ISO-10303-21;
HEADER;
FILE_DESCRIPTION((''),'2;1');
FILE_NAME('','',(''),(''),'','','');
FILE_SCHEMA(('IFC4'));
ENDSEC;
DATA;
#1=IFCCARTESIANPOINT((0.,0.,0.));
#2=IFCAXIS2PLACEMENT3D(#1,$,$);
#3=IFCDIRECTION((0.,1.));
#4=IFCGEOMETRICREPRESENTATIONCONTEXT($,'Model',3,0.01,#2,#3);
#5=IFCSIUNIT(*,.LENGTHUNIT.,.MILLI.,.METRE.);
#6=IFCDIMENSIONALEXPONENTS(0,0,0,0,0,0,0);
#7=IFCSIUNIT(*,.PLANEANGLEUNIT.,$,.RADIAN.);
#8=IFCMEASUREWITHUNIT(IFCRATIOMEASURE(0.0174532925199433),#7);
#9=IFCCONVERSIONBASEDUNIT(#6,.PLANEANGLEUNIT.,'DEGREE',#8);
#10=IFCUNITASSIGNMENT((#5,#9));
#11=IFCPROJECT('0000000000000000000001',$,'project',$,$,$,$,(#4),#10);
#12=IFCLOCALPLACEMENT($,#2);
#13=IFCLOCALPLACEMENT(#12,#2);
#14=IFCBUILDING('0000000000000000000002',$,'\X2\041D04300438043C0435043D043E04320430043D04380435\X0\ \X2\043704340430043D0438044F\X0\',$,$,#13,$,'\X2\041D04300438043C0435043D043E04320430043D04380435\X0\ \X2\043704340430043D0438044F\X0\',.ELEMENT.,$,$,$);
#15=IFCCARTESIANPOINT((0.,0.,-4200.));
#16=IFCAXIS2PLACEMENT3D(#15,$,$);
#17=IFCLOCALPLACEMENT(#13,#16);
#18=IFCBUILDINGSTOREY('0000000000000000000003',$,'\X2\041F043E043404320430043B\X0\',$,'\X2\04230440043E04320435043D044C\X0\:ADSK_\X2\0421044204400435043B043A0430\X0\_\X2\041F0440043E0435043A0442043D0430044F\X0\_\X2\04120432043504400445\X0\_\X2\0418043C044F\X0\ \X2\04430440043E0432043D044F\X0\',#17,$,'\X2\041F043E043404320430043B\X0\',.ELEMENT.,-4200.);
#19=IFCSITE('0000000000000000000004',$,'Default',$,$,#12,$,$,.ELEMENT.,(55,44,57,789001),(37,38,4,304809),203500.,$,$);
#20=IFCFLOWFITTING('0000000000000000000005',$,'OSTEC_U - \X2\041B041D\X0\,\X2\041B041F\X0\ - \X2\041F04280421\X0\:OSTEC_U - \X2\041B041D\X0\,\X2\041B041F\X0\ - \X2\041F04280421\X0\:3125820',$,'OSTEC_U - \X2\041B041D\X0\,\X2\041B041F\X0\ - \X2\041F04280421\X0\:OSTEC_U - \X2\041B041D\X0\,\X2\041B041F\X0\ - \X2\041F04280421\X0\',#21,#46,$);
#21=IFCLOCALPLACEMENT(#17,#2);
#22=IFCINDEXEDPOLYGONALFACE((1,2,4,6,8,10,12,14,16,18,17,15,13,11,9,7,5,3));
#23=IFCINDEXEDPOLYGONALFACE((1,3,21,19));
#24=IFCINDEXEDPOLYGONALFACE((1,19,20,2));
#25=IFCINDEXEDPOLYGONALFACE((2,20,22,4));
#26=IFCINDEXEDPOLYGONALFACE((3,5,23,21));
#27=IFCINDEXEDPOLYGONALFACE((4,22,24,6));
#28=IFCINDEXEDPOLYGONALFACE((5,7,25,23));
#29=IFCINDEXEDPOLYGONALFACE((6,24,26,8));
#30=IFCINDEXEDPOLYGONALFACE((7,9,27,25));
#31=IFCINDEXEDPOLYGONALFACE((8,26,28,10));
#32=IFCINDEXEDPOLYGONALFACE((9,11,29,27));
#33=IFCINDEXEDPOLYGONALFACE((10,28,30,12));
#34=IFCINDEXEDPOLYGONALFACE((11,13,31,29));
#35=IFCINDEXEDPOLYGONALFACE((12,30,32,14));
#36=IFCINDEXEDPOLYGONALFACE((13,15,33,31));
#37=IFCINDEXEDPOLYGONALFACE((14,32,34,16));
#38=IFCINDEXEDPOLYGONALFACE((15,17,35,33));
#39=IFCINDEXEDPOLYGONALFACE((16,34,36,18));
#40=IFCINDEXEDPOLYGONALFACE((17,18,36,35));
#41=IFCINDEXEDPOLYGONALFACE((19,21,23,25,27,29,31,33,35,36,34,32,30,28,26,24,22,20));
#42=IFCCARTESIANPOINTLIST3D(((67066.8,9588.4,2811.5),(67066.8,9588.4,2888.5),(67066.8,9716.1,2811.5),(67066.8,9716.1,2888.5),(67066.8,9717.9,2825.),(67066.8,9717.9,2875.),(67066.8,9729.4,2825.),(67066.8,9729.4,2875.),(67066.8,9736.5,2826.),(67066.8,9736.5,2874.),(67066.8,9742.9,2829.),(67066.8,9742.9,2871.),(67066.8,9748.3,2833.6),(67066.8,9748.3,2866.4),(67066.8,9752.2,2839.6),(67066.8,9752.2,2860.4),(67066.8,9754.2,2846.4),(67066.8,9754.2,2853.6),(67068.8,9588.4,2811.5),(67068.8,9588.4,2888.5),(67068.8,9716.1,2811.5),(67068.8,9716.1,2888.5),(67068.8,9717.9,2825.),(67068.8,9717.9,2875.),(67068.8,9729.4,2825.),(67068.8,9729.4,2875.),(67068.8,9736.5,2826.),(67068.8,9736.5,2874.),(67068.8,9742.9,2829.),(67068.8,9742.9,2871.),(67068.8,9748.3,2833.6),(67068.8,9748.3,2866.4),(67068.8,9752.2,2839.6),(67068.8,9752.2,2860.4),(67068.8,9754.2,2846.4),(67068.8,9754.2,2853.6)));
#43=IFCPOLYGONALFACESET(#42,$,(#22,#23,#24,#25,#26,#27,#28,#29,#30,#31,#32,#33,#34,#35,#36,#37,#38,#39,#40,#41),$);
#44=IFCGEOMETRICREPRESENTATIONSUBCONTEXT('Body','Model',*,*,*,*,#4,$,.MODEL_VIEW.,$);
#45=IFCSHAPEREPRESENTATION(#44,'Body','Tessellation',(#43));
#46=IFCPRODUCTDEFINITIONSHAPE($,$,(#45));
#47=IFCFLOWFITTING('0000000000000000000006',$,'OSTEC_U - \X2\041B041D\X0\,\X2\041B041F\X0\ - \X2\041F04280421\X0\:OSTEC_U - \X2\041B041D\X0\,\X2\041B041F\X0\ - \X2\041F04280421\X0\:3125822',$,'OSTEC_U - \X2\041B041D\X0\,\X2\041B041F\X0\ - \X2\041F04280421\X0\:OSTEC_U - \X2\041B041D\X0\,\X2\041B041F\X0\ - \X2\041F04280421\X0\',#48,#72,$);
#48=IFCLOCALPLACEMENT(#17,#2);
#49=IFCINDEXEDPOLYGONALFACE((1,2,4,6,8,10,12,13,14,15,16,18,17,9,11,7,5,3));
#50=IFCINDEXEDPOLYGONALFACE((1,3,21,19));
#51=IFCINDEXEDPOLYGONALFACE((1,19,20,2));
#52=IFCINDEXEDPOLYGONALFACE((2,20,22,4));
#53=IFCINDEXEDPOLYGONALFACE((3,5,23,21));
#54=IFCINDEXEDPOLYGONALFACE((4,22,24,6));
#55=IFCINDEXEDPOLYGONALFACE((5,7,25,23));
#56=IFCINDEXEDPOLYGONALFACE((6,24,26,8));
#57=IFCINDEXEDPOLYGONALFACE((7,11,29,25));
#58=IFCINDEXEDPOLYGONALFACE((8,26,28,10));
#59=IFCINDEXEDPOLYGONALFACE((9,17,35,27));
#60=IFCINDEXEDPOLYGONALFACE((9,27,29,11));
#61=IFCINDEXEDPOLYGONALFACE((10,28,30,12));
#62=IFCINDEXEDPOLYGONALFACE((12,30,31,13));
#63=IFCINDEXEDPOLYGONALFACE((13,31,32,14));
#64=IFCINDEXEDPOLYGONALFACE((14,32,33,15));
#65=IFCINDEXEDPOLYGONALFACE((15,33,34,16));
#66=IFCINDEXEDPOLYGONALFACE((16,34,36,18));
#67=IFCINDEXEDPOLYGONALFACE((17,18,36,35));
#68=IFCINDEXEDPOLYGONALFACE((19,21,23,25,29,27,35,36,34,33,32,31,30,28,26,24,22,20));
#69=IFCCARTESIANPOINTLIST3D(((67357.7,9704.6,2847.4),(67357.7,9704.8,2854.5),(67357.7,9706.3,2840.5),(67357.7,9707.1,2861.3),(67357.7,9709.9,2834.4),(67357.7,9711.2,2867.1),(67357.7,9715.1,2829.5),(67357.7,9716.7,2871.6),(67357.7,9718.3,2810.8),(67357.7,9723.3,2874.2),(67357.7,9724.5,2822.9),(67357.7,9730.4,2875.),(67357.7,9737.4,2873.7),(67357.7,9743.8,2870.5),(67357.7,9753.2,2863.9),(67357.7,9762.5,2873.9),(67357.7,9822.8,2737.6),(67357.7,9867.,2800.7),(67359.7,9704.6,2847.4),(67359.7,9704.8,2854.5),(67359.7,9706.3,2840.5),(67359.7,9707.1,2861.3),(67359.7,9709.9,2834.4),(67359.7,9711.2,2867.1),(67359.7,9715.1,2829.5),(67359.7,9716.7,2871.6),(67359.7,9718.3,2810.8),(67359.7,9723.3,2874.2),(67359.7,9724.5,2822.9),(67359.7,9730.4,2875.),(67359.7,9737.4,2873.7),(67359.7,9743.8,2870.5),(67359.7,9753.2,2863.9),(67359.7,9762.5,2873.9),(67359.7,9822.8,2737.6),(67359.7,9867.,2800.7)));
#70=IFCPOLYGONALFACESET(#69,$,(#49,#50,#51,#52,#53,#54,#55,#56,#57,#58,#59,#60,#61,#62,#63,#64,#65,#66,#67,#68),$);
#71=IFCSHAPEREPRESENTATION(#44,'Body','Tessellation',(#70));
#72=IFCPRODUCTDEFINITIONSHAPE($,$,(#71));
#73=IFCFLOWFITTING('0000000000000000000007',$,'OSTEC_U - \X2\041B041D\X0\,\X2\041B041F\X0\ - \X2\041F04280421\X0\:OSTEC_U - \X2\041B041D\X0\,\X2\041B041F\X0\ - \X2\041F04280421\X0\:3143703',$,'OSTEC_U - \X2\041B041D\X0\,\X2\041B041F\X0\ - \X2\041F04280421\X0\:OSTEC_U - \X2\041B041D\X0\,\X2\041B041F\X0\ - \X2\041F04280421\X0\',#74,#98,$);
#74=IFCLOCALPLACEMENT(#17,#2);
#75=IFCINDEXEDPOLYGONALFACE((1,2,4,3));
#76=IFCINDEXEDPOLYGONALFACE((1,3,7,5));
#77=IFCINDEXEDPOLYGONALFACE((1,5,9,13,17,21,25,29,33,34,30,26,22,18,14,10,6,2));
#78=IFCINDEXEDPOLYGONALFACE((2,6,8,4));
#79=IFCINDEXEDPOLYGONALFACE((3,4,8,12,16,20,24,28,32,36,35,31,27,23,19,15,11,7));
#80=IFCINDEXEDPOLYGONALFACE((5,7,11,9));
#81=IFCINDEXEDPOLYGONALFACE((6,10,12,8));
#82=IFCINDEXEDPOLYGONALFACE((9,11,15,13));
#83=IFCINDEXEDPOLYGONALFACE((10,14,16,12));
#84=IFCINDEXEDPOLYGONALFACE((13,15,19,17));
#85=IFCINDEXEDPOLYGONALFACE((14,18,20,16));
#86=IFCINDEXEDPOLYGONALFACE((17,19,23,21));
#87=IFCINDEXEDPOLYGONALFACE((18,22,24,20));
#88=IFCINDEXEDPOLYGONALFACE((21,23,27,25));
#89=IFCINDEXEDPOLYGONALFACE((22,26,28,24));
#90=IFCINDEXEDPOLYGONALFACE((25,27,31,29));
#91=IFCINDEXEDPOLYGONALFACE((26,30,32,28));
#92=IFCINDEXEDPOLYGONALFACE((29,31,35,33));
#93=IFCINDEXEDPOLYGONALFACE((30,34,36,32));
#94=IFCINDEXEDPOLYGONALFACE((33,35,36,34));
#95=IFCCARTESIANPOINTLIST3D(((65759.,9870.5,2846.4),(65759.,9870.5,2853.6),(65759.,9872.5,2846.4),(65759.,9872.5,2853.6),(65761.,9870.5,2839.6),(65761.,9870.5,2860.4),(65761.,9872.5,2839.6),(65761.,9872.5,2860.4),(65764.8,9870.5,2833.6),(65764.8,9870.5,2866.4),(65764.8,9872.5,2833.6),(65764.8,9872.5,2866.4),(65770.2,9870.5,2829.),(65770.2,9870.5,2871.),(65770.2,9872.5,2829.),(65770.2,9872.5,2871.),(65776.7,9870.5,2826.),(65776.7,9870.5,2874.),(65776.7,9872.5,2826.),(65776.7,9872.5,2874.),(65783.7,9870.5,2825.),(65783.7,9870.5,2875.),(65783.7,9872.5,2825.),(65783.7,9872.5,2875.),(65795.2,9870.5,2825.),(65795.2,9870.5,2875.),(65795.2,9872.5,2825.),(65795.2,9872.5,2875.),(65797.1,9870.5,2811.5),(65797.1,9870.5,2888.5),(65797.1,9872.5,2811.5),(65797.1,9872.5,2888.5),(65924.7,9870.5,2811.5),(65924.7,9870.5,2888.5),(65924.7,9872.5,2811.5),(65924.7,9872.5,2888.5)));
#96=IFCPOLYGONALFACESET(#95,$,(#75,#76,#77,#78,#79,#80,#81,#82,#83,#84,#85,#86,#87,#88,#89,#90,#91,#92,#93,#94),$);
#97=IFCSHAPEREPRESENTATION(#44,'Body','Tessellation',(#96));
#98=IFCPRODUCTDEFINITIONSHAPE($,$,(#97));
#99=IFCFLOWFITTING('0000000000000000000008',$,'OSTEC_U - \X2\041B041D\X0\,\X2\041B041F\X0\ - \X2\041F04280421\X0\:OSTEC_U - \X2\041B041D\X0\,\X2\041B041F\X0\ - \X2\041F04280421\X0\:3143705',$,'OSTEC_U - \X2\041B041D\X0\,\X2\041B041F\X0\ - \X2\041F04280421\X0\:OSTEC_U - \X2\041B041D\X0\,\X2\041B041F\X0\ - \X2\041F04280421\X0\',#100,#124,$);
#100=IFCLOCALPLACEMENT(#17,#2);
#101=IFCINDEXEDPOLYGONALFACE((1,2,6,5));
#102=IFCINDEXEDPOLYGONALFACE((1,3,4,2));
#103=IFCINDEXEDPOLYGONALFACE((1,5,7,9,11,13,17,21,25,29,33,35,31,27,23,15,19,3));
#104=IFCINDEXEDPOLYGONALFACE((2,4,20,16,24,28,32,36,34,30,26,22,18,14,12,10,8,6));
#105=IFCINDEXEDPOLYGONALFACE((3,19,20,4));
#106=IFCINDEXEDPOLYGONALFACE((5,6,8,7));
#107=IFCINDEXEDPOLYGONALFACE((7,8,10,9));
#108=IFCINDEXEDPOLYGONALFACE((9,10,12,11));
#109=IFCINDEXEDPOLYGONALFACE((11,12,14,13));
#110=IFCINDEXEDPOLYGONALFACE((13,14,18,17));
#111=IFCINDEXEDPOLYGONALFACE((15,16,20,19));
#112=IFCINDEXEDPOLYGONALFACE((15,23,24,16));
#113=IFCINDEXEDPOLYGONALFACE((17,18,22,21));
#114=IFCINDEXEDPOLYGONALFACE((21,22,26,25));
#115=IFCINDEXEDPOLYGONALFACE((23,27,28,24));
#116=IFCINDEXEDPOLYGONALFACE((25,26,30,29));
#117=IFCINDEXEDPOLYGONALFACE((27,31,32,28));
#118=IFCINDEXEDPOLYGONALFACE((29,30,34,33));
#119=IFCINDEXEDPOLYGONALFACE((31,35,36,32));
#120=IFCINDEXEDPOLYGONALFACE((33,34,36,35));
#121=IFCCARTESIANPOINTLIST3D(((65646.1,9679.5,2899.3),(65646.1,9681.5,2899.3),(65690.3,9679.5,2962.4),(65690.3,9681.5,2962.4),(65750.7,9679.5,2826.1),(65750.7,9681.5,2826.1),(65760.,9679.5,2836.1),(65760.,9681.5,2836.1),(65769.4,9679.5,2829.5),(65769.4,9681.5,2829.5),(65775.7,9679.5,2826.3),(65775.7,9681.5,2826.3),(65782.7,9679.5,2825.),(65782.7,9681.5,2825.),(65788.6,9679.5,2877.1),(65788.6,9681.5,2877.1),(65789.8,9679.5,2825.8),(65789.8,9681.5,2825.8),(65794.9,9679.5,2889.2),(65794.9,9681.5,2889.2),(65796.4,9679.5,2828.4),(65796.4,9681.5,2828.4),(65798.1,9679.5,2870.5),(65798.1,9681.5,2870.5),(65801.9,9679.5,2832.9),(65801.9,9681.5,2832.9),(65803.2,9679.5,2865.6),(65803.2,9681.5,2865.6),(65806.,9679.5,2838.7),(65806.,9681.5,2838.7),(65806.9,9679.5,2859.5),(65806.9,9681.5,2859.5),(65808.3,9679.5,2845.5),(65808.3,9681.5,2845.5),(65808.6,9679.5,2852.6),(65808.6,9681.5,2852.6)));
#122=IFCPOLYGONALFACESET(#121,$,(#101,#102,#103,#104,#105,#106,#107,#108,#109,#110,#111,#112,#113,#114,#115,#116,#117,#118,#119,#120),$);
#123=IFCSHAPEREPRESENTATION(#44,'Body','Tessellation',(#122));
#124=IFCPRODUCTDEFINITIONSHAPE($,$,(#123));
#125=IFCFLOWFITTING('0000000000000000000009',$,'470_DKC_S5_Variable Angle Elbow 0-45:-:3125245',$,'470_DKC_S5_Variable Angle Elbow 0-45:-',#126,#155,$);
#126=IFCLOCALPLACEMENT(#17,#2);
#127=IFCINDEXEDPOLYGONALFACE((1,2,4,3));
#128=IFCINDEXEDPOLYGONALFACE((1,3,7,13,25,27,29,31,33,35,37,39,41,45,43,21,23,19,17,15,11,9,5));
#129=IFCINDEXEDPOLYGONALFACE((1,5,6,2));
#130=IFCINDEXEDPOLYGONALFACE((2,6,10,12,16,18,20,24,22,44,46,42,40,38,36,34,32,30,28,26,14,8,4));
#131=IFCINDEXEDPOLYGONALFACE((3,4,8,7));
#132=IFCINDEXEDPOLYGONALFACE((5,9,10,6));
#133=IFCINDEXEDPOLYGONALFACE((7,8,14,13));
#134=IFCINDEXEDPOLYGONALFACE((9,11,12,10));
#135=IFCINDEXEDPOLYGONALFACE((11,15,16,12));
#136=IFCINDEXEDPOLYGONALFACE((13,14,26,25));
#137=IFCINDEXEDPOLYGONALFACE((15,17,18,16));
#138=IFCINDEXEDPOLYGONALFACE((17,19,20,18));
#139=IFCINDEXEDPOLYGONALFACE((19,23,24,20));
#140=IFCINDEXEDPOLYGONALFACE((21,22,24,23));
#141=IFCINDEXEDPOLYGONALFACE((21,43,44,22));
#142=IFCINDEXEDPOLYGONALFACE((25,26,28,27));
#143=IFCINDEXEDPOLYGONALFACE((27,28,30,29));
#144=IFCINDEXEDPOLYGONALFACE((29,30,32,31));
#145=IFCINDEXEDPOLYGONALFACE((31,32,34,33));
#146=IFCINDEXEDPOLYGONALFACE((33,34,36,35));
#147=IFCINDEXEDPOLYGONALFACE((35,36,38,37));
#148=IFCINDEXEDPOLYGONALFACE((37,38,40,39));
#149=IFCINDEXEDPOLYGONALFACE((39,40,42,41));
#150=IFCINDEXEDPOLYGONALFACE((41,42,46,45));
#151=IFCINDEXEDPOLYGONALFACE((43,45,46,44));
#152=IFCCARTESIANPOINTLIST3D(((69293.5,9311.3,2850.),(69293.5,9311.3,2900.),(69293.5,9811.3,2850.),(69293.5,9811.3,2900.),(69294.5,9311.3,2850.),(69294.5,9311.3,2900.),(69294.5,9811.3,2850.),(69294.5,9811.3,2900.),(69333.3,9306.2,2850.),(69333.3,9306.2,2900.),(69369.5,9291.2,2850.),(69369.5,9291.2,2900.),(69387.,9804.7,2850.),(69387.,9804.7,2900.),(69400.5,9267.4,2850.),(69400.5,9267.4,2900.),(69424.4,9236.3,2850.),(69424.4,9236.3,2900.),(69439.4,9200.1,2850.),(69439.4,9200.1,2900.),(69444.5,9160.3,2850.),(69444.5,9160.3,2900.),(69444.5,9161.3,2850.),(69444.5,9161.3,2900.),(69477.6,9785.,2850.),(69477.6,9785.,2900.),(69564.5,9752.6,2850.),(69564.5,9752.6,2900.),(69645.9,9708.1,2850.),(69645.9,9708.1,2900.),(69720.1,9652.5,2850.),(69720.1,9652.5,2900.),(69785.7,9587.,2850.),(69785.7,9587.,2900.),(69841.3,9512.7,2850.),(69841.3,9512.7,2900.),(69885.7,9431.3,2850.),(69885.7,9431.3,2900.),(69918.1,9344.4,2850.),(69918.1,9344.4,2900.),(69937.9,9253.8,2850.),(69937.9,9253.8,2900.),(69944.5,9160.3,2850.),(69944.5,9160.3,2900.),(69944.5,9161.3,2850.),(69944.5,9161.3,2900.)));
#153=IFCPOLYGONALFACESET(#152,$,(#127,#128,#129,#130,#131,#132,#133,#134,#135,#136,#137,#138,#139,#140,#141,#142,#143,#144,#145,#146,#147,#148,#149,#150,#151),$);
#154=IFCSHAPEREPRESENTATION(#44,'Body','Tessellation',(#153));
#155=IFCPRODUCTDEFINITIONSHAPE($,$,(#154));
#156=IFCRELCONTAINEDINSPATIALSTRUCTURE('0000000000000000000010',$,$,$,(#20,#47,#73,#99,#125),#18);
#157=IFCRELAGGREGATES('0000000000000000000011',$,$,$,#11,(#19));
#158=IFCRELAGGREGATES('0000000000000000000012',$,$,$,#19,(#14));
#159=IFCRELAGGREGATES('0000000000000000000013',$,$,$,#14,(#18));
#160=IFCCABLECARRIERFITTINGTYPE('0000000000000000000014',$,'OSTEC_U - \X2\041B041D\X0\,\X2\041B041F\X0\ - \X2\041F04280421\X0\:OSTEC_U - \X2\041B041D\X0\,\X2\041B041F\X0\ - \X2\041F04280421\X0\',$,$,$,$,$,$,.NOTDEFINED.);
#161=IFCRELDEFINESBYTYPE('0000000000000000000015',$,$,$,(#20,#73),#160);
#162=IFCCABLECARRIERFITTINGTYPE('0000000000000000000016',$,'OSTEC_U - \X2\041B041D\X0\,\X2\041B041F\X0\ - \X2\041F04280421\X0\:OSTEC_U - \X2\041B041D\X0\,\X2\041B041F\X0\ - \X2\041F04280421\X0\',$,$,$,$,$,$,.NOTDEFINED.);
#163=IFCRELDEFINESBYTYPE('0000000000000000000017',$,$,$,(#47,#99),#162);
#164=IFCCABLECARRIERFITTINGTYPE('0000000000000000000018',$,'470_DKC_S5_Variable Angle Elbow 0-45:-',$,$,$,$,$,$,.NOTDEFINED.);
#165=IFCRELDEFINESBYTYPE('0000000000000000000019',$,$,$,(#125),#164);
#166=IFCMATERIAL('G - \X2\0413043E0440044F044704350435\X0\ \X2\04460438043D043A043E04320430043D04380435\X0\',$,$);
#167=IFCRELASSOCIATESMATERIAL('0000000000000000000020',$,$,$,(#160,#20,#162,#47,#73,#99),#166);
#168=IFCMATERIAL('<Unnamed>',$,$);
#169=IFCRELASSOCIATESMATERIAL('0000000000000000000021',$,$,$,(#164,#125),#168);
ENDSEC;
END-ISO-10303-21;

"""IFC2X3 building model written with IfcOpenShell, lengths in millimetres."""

from ifc_helpers import new_model, entity, si_unit, converted_unit, direction, frame, frame_2d, origin, place, context, subcontext, project, spatial, polyline, circle_curve, parameter, trimmed, segment, composite_curve, outline, extrude, source, transform, mapped, material, type_object, type_shapes, element, save


model = new_model("IFC2X3")

# Units and contexts
model_context = context("Model", 3, precision=0.01, world=origin(), true_north=direction((0.0, 1.0)))
body_context = subcontext(model_context, "Body", "Model", "MODEL_VIEW")
ifc_project = project(units=[si_unit("LENGTHUNIT", "METRE", prefix="MILLI"), converted_unit("PLANEANGLEUNIT", "DEGREE", entity("IfcRatioMeasure", 0.0174532925199433), si_unit("PLANEANGLEUNIT", "RADIAN"), dimensions=[0, 0, 0, 0, 0, 0, 0])], contexts=[model_context])

# Site, building, storey
site_placement = place(None, origin())
site = spatial("IfcSite", under=ifc_project, at=site_placement, Name="Default", CompositionType="ELEMENT", RefLatitude=(55, 44, 57, 789001), RefLongitude=(37, 38, 4, 304809), RefElevation=203500.0)
building_placement = place(site_placement, origin())
building = spatial("IfcBuilding", under=site, at=building_placement, Name="Наименование здания", LongName="Наименование здания", CompositionType="ELEMENT")
storey_placement = place(building_placement, frame((0.0, 0.0, -4200.0)))
storey = spatial("IfcBuildingStorey", under=building, at=storey_placement, Name="Подвал", ObjectType="Уровень:ADSK_Стрелка_Проектная_Вверх_Имя уровня", LongName="Подвал", CompositionType="ELEMENT", Elevation=-4200.0)

# Flow fittings
ifc_material_1 = material(Name="G - Горячее цинкование")
cable_carrier_fitting_type_1 = type_object("IfcCableCarrierFittingType", Name="OSTEC_U - ЛН,ЛП - ПШС:OSTEC_U - ЛН,ЛП - ПШС", PredefinedType="NOTDEFINED", material=ifc_material_1)
shared_shape_1 = source(origin(), body_context, "Body", "SweptSolid", [
    extrude(outline(composite_curve([segment(trimmed(circle_curve(frame_2d((-41.5, 0.0), x_axis=(1.0, 0.0)), 25.0), [parameter(90.0)], [parameter(270.0)], True, "PARAMETER"), True, "CONTINUOUS"), segment(polyline([(-41.5, -25.0), (-30.0, -25.0)]), True, "CONTINUOUS"), segment(polyline([(-30.0, -25.0), (-28.1, -38.5)]), True, "CONTINUOUS"), segment(polyline([(-28.1, -38.5), (99.5, -38.5)]), True, "CONTINUOUS"), segment(polyline([(99.5, -38.5), (99.5, 38.5)]), True, "CONTINUOUS"), segment(polyline([(99.5, 38.5), (-28.1, 38.5)]), True, "CONTINUOUS"), segment(polyline([(-28.1, 38.5), (-30.0, 25.0)]), True, "CONTINUOUS"), segment(polyline([(-30.0, 25.0), (-41.5, 25.0)]), True, "CONTINUOUS")], self_intersect=False)), frame((41.5, 0.0, 0.0)), (0.0, 0.0, 1.0), 2.0),
])
type_shapes(cable_carrier_fitting_type_1, [shared_shape_1])
flow_fitting_1_placement = place(storey_placement, frame((67068.8, 9729.4, 2850.0), z_axis=(-1.0, 0.0, 0.0), x_axis=(0.0, -1.0, 0.0)))
element("IfcFlowFitting", 1, at=flow_fitting_1_placement, inside=storey, type_object=cable_carrier_fitting_type_1, material=ifc_material_1, Name="OSTEC_U - ЛН,ЛП - ПШС:OSTEC_U - ЛН,ЛП - ПШС:3125820", ObjectType="OSTEC_U - ЛН,ЛП - ПШС:OSTEC_U - ЛН,ЛП - ПШС", context=body_context, shape_type="MappedRepresentation", body=[
    mapped(shared_shape_1, transform((0.0, 0.0, 0.0), scale=1.0)),
])
cable_carrier_fitting_type_2 = type_object("IfcCableCarrierFittingType", Name="OSTEC_U - ЛН,ЛП - ПШС:OSTEC_U - ЛН,ЛП - ПШС", PredefinedType="NOTDEFINED", material=ifc_material_1)
type_shapes(cable_carrier_fitting_type_2, [shared_shape_1])
flow_fitting_2_placement = place(storey_placement, frame((67357.7, 9729.4, 2850.0), z_axis=(1.0, 0.0, 0.0), x_axis=(0.0, 0.819152, -0.573576)))
element("IfcFlowFitting", 2, at=flow_fitting_2_placement, inside=storey, type_object=cable_carrier_fitting_type_2, material=ifc_material_1, Name="OSTEC_U - ЛН,ЛП - ПШС:OSTEC_U - ЛН,ЛП - ПШС:3125822", ObjectType="OSTEC_U - ЛН,ЛП - ПШС:OSTEC_U - ЛН,ЛП - ПШС", context=body_context, shape_type="MappedRepresentation", body=[
    mapped(shared_shape_1, transform((0.0, 0.0, 0.0), scale=1.0)),
])
flow_fitting_3_placement = place(storey_placement, frame((65783.7, 9870.5, 2850.0), z_axis=(0.0, 1.0, 0.0), x_axis=(1.0, 0.0, 0.0)))
element("IfcFlowFitting", 3, at=flow_fitting_3_placement, inside=storey, type_object=cable_carrier_fitting_type_1, material=ifc_material_1, Name="OSTEC_U - ЛН,ЛП - ПШС:OSTEC_U - ЛН,ЛП - ПШС:3143703", ObjectType="OSTEC_U - ЛН,ЛП - ПШС:OSTEC_U - ЛН,ЛП - ПШС", context=body_context, shape_type="MappedRepresentation", body=[
    mapped(shared_shape_1, transform((0.0, 0.0, 0.0), scale=1.0)),
])
flow_fitting_4_placement = place(storey_placement, frame((65783.7, 9681.5, 2850.0), z_axis=(0.0, -1.0, 0.0), x_axis=(-0.819152, 0.0, 0.573576)))
element("IfcFlowFitting", 4, at=flow_fitting_4_placement, inside=storey, type_object=cable_carrier_fitting_type_2, material=ifc_material_1, Name="OSTEC_U - ЛН,ЛП - ПШС:OSTEC_U - ЛН,ЛП - ПШС:3143705", ObjectType="OSTEC_U - ЛН,ЛП - ПШС:OSTEC_U - ЛН,ЛП - ПШС", context=body_context, shape_type="MappedRepresentation", body=[
    mapped(shared_shape_1, transform((0.0, 0.0, 0.0), scale=1.0)),
])
ifc_material_2 = material(Name="<Unnamed>")
cable_carrier_fitting_type_3 = type_object("IfcCableCarrierFittingType", Name="470_DKC_S5_Variable Angle Elbow 0-45:-", PredefinedType="NOTDEFINED", material=ifc_material_2)
shared_shape_2 = source(origin(), body_context, "Body", "SweptSolid", [
    extrude(outline(composite_curve([segment(polyline([(-200.8, -450.2), (-199.8, -450.2)]), True, "CONTINUOUS"), segment(trimmed(circle_curve(frame_2d((-199.8, 199.8), x_axis=(0.0, -1.0)), 650.0), [parameter(0.0)], [parameter(90.0)], True, "PARAMETER"), True, "CONTINUOUS"), segment(polyline([(450.2, 199.8), (450.2, 200.8)]), True, "CONTINUOUS"), segment(polyline([(450.2, 200.8), (-49.8, 200.8)]), True, "CONTINUOUS"), segment(polyline([(-49.8, 200.8), (-49.8, 199.8)]), True, "CONTINUOUS"), segment(trimmed(circle_curve(frame_2d((-199.8, 199.8), x_axis=(0.0, -1.0)), 150.0), [parameter(0.0)], [parameter(90.0)], True, "PARAMETER"), False, "CONTINUOUS"), segment(polyline([(-199.8, 49.8), (-200.8, 49.8)]), True, "CONTINUOUS"), segment(polyline([(-200.8, 49.8), (-200.8, -450.2)]), True, "CONTINUOUS")], self_intersect=False)), frame((-200.2, 200.2, -25.0)), (0.0, 0.0, 1.0), 50.0),
])
type_shapes(cable_carrier_fitting_type_3, [shared_shape_2])
for number, where, z_axis, x_axis, name in (
    (5, (69694.5, 9561.3, 2875.0), (0.0, 0.0, 1.0), (0.0, 1.0, 0.0), "470_DKC_S5_Variable Angle Elbow 0-45:-:3125245"),
):
    element("IfcFlowFitting", number, at=place(storey_placement, frame(where, z_axis=z_axis, x_axis=x_axis)), inside=storey, type_object=cable_carrier_fitting_type_3, material=ifc_material_2, Name=name, ObjectType="470_DKC_S5_Variable Angle Elbow 0-45:-", context=body_context, shape_type="MappedRepresentation", body=[
        mapped(shared_shape_2, transform((0.0, 0.0, 0.0), scale=1.0)),
    ])

save(model, "model.ifc")
